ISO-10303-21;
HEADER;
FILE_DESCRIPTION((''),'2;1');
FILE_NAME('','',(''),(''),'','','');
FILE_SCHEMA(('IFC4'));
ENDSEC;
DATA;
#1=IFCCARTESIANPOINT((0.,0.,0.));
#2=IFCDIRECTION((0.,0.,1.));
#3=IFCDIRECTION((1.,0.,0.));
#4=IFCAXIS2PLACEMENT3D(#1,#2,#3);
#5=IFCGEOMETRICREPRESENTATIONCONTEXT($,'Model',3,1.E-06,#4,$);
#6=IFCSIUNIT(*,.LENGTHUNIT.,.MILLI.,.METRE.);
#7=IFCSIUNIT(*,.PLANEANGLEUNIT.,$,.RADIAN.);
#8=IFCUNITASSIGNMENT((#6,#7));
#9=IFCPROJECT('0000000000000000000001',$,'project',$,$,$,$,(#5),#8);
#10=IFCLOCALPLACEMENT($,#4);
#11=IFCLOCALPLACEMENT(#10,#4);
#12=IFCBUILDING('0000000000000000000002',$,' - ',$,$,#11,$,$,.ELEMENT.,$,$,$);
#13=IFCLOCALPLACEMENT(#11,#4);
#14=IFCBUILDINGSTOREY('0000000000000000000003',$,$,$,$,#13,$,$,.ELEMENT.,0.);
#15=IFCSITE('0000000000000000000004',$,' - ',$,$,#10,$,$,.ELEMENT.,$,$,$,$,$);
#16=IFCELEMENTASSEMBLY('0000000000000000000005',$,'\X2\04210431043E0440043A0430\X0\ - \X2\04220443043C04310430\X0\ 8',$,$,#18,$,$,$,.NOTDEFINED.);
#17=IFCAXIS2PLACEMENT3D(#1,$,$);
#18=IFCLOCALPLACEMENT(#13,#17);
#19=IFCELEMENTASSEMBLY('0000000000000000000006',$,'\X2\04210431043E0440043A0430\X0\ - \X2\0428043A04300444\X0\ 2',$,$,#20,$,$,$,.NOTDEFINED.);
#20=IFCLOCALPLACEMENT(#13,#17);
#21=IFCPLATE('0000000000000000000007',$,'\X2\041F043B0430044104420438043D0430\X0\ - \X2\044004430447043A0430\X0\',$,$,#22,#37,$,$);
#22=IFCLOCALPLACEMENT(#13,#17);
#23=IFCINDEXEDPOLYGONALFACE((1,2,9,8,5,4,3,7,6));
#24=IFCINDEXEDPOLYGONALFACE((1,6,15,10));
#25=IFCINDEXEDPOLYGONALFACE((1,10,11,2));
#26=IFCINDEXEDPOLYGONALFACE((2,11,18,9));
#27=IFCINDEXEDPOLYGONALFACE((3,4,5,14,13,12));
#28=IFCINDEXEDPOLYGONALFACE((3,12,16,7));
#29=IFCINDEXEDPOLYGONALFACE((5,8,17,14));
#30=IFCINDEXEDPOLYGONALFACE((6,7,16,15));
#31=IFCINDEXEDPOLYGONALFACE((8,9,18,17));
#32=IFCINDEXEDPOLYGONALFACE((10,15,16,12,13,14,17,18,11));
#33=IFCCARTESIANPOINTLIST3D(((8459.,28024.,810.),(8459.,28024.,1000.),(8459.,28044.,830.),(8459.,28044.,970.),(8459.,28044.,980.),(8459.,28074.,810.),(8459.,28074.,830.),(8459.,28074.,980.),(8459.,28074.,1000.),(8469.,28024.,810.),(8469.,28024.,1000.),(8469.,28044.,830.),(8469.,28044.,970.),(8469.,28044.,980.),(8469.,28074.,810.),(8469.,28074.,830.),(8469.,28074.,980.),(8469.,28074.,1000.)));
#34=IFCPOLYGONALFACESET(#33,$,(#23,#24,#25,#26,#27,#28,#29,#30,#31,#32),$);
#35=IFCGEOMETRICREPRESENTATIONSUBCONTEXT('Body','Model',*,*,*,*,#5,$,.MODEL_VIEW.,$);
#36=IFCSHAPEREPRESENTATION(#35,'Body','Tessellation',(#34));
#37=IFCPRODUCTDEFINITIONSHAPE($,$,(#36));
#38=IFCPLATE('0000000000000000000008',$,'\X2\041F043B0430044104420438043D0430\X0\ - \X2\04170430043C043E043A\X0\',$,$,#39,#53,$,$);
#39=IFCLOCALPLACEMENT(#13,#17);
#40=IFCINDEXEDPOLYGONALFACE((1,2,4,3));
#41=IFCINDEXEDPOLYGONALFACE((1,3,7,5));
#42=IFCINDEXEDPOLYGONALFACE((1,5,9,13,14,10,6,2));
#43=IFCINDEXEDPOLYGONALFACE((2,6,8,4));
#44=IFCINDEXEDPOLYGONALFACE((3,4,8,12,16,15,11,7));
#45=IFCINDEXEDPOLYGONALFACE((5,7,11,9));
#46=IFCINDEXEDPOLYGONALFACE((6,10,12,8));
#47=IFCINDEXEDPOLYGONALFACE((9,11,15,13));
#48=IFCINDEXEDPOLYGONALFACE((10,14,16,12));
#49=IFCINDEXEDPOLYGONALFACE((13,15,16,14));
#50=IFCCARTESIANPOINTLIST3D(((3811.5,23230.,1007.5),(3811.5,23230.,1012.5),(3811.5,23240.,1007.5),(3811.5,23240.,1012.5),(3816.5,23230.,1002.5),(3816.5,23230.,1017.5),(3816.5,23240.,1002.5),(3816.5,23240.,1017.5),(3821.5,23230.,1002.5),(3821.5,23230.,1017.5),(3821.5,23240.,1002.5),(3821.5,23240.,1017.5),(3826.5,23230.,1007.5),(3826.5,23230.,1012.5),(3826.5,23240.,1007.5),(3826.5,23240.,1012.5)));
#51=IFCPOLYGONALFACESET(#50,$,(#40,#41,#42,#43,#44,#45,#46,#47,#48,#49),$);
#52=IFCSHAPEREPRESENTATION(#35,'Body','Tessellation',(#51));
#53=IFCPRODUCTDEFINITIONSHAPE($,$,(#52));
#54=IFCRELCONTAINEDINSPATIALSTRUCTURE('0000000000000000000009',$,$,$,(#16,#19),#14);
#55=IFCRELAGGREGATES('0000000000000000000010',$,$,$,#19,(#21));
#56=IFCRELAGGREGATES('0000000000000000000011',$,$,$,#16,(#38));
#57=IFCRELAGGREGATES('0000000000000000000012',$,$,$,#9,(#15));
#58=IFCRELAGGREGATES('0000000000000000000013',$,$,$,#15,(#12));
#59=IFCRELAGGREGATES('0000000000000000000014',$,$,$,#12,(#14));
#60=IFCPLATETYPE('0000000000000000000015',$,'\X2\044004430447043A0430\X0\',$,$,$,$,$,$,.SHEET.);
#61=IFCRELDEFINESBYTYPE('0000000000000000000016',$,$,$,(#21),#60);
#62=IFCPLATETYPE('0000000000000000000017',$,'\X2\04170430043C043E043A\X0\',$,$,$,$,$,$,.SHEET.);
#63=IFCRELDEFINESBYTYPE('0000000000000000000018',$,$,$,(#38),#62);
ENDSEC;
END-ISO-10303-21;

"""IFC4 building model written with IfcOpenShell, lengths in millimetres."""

from ifc_helpers import new_model, si_unit, frame, origin_with_axes, place, context, subcontext, project, spatial, line, indexed_curve, outline, extrude, source, transform, mapped, type_object, element, aggregate, save


model = new_model("IFC4")

# Units and contexts
model_context = context("Model", 3, precision=1e-06, world=origin_with_axes())
body_context = subcontext(model_context, "Body", "Model", "MODEL_VIEW")
ifc_project = project(units=[si_unit("LENGTHUNIT", "METRE", prefix="MILLI"), si_unit("PLANEANGLEUNIT", "RADIAN")], contexts=[model_context])

# Site, building, storey
site_placement = place(None, origin_with_axes())
site = spatial("IfcSite", under=ifc_project, at=site_placement, Name=" - ", CompositionType="ELEMENT")
building_placement = place(site_placement, origin_with_axes())
building = spatial("IfcBuilding", under=site, at=building_placement, Name=" - ", CompositionType="ELEMENT")
storey_placement = place(building_placement, origin_with_axes())
storey = spatial("IfcBuildingStorey", under=building, at=storey_placement, CompositionType="ELEMENT", Elevation=0.0)

# Shared definitions
plate_type_1 = type_object("IfcPlateType", Name="ручка", PredefinedType="SHEET")

# Element assemblies
assembly_1_placement = place(storey_placement, frame((3854.0, 23030.0, 0.0), z_axis=(0.0, 0.0, 1.0), x_axis=(-1.0, 0.0, 0.0)))
assembly_1 = element("IfcElementAssembly", 1, at=assembly_1_placement, inside=storey, Name="Сборка - Тумба 8", PredefinedType="NOTDEFINED")
assembly_2_placement = place(storey_placement, frame((7899.0, 28074.0, 0.0), z_axis=(0.0, 0.0, 1.0), x_axis=(1.0, 0.0, 0.0)))
assembly_2 = element("IfcElementAssembly", 2, at=assembly_2_placement, inside=storey, Name="Сборка - Шкаф 2", PredefinedType="NOTDEFINED")

# Plates
shared_shape_1 = source(origin_with_axes(), body_context, "Body", "SweptSolid", [
    extrude(outline(indexed_curve([(-95.0, -25.0), (-75.0, -25.0), (-75.0, 5.0), (-65.0, 5.0), (75.0, 5.0), (75.0, -25.0), (95.0, -25.0), (95.0, 25.0), (-95.0, 25.0)], segments=[line(1, 2), line(2, 3), line(3, 4), line(4, 5), line(5, 6), line(6, 7), line(7, 8), line(8, 9), line(9, 1)])), origin_with_axes(), (0.0, 0.0, 1.0), 10.0),
])
plate_1_placement = place(assembly_2_placement, frame((570.0, -25.0, 905.0), z_axis=(-1.0, 0.0, 0.0), x_axis=(0.0, 0.0, -1.0)))
plate_1 = element("IfcPlate", 3, at=plate_1_placement, type_object=plate_type_1, Name="Пластина - ручка", context=body_context, shape_type="MappedRepresentation", body=[
    mapped(shared_shape_1, transform((0.0, 0.0, 0.0), x_axis=(1.0, 0.0, 0.0), y_axis=(0.0, 1.0, 0.0), z_axis=(0.0, 0.0, 1.0), scale=1.0)),
])
aggregate(assembly_2, [plate_1])
plate_type_2 = type_object("IfcPlateType", Name="Замок", PredefinedType="SHEET")
shared_shape_2 = source(origin_with_axes(), body_context, "Body", "SweptSolid", [
    extrude(outline(indexed_curve([(-2.5, 7.5), (-7.5, 2.5), (-7.5, -2.5), (-2.5, -7.5), (2.5, -7.5), (7.5, -2.5), (7.5, 2.5), (2.5, 7.5)], segments=[line(1, 2), line(2, 3), line(3, 4), line(4, 5), line(5, 6), line(6, 7), line(7, 8), line(8, 1)])), origin_with_axes(), (0.0, 0.0, 1.0), 10.0),
])
plate_2_placement = place(assembly_1_placement, frame((35.0, -200.0, 1010.0), z_axis=(0.0, -1.0, 0.0), x_axis=(0.0, 0.0, 1.0)))
plate_2 = element("IfcPlate", 4, at=plate_2_placement, type_object=plate_type_2, Name="Пластина - Замок", context=body_context, shape_type="MappedRepresentation", body=[
    mapped(shared_shape_2, transform((0.0, 0.0, 0.0), x_axis=(1.0, 0.0, 0.0), y_axis=(0.0, 1.0, 0.0), z_axis=(0.0, 0.0, 1.0), scale=1.0)),
])
aggregate(assembly_1, [plate_2])

save(model, "model.ifc")
